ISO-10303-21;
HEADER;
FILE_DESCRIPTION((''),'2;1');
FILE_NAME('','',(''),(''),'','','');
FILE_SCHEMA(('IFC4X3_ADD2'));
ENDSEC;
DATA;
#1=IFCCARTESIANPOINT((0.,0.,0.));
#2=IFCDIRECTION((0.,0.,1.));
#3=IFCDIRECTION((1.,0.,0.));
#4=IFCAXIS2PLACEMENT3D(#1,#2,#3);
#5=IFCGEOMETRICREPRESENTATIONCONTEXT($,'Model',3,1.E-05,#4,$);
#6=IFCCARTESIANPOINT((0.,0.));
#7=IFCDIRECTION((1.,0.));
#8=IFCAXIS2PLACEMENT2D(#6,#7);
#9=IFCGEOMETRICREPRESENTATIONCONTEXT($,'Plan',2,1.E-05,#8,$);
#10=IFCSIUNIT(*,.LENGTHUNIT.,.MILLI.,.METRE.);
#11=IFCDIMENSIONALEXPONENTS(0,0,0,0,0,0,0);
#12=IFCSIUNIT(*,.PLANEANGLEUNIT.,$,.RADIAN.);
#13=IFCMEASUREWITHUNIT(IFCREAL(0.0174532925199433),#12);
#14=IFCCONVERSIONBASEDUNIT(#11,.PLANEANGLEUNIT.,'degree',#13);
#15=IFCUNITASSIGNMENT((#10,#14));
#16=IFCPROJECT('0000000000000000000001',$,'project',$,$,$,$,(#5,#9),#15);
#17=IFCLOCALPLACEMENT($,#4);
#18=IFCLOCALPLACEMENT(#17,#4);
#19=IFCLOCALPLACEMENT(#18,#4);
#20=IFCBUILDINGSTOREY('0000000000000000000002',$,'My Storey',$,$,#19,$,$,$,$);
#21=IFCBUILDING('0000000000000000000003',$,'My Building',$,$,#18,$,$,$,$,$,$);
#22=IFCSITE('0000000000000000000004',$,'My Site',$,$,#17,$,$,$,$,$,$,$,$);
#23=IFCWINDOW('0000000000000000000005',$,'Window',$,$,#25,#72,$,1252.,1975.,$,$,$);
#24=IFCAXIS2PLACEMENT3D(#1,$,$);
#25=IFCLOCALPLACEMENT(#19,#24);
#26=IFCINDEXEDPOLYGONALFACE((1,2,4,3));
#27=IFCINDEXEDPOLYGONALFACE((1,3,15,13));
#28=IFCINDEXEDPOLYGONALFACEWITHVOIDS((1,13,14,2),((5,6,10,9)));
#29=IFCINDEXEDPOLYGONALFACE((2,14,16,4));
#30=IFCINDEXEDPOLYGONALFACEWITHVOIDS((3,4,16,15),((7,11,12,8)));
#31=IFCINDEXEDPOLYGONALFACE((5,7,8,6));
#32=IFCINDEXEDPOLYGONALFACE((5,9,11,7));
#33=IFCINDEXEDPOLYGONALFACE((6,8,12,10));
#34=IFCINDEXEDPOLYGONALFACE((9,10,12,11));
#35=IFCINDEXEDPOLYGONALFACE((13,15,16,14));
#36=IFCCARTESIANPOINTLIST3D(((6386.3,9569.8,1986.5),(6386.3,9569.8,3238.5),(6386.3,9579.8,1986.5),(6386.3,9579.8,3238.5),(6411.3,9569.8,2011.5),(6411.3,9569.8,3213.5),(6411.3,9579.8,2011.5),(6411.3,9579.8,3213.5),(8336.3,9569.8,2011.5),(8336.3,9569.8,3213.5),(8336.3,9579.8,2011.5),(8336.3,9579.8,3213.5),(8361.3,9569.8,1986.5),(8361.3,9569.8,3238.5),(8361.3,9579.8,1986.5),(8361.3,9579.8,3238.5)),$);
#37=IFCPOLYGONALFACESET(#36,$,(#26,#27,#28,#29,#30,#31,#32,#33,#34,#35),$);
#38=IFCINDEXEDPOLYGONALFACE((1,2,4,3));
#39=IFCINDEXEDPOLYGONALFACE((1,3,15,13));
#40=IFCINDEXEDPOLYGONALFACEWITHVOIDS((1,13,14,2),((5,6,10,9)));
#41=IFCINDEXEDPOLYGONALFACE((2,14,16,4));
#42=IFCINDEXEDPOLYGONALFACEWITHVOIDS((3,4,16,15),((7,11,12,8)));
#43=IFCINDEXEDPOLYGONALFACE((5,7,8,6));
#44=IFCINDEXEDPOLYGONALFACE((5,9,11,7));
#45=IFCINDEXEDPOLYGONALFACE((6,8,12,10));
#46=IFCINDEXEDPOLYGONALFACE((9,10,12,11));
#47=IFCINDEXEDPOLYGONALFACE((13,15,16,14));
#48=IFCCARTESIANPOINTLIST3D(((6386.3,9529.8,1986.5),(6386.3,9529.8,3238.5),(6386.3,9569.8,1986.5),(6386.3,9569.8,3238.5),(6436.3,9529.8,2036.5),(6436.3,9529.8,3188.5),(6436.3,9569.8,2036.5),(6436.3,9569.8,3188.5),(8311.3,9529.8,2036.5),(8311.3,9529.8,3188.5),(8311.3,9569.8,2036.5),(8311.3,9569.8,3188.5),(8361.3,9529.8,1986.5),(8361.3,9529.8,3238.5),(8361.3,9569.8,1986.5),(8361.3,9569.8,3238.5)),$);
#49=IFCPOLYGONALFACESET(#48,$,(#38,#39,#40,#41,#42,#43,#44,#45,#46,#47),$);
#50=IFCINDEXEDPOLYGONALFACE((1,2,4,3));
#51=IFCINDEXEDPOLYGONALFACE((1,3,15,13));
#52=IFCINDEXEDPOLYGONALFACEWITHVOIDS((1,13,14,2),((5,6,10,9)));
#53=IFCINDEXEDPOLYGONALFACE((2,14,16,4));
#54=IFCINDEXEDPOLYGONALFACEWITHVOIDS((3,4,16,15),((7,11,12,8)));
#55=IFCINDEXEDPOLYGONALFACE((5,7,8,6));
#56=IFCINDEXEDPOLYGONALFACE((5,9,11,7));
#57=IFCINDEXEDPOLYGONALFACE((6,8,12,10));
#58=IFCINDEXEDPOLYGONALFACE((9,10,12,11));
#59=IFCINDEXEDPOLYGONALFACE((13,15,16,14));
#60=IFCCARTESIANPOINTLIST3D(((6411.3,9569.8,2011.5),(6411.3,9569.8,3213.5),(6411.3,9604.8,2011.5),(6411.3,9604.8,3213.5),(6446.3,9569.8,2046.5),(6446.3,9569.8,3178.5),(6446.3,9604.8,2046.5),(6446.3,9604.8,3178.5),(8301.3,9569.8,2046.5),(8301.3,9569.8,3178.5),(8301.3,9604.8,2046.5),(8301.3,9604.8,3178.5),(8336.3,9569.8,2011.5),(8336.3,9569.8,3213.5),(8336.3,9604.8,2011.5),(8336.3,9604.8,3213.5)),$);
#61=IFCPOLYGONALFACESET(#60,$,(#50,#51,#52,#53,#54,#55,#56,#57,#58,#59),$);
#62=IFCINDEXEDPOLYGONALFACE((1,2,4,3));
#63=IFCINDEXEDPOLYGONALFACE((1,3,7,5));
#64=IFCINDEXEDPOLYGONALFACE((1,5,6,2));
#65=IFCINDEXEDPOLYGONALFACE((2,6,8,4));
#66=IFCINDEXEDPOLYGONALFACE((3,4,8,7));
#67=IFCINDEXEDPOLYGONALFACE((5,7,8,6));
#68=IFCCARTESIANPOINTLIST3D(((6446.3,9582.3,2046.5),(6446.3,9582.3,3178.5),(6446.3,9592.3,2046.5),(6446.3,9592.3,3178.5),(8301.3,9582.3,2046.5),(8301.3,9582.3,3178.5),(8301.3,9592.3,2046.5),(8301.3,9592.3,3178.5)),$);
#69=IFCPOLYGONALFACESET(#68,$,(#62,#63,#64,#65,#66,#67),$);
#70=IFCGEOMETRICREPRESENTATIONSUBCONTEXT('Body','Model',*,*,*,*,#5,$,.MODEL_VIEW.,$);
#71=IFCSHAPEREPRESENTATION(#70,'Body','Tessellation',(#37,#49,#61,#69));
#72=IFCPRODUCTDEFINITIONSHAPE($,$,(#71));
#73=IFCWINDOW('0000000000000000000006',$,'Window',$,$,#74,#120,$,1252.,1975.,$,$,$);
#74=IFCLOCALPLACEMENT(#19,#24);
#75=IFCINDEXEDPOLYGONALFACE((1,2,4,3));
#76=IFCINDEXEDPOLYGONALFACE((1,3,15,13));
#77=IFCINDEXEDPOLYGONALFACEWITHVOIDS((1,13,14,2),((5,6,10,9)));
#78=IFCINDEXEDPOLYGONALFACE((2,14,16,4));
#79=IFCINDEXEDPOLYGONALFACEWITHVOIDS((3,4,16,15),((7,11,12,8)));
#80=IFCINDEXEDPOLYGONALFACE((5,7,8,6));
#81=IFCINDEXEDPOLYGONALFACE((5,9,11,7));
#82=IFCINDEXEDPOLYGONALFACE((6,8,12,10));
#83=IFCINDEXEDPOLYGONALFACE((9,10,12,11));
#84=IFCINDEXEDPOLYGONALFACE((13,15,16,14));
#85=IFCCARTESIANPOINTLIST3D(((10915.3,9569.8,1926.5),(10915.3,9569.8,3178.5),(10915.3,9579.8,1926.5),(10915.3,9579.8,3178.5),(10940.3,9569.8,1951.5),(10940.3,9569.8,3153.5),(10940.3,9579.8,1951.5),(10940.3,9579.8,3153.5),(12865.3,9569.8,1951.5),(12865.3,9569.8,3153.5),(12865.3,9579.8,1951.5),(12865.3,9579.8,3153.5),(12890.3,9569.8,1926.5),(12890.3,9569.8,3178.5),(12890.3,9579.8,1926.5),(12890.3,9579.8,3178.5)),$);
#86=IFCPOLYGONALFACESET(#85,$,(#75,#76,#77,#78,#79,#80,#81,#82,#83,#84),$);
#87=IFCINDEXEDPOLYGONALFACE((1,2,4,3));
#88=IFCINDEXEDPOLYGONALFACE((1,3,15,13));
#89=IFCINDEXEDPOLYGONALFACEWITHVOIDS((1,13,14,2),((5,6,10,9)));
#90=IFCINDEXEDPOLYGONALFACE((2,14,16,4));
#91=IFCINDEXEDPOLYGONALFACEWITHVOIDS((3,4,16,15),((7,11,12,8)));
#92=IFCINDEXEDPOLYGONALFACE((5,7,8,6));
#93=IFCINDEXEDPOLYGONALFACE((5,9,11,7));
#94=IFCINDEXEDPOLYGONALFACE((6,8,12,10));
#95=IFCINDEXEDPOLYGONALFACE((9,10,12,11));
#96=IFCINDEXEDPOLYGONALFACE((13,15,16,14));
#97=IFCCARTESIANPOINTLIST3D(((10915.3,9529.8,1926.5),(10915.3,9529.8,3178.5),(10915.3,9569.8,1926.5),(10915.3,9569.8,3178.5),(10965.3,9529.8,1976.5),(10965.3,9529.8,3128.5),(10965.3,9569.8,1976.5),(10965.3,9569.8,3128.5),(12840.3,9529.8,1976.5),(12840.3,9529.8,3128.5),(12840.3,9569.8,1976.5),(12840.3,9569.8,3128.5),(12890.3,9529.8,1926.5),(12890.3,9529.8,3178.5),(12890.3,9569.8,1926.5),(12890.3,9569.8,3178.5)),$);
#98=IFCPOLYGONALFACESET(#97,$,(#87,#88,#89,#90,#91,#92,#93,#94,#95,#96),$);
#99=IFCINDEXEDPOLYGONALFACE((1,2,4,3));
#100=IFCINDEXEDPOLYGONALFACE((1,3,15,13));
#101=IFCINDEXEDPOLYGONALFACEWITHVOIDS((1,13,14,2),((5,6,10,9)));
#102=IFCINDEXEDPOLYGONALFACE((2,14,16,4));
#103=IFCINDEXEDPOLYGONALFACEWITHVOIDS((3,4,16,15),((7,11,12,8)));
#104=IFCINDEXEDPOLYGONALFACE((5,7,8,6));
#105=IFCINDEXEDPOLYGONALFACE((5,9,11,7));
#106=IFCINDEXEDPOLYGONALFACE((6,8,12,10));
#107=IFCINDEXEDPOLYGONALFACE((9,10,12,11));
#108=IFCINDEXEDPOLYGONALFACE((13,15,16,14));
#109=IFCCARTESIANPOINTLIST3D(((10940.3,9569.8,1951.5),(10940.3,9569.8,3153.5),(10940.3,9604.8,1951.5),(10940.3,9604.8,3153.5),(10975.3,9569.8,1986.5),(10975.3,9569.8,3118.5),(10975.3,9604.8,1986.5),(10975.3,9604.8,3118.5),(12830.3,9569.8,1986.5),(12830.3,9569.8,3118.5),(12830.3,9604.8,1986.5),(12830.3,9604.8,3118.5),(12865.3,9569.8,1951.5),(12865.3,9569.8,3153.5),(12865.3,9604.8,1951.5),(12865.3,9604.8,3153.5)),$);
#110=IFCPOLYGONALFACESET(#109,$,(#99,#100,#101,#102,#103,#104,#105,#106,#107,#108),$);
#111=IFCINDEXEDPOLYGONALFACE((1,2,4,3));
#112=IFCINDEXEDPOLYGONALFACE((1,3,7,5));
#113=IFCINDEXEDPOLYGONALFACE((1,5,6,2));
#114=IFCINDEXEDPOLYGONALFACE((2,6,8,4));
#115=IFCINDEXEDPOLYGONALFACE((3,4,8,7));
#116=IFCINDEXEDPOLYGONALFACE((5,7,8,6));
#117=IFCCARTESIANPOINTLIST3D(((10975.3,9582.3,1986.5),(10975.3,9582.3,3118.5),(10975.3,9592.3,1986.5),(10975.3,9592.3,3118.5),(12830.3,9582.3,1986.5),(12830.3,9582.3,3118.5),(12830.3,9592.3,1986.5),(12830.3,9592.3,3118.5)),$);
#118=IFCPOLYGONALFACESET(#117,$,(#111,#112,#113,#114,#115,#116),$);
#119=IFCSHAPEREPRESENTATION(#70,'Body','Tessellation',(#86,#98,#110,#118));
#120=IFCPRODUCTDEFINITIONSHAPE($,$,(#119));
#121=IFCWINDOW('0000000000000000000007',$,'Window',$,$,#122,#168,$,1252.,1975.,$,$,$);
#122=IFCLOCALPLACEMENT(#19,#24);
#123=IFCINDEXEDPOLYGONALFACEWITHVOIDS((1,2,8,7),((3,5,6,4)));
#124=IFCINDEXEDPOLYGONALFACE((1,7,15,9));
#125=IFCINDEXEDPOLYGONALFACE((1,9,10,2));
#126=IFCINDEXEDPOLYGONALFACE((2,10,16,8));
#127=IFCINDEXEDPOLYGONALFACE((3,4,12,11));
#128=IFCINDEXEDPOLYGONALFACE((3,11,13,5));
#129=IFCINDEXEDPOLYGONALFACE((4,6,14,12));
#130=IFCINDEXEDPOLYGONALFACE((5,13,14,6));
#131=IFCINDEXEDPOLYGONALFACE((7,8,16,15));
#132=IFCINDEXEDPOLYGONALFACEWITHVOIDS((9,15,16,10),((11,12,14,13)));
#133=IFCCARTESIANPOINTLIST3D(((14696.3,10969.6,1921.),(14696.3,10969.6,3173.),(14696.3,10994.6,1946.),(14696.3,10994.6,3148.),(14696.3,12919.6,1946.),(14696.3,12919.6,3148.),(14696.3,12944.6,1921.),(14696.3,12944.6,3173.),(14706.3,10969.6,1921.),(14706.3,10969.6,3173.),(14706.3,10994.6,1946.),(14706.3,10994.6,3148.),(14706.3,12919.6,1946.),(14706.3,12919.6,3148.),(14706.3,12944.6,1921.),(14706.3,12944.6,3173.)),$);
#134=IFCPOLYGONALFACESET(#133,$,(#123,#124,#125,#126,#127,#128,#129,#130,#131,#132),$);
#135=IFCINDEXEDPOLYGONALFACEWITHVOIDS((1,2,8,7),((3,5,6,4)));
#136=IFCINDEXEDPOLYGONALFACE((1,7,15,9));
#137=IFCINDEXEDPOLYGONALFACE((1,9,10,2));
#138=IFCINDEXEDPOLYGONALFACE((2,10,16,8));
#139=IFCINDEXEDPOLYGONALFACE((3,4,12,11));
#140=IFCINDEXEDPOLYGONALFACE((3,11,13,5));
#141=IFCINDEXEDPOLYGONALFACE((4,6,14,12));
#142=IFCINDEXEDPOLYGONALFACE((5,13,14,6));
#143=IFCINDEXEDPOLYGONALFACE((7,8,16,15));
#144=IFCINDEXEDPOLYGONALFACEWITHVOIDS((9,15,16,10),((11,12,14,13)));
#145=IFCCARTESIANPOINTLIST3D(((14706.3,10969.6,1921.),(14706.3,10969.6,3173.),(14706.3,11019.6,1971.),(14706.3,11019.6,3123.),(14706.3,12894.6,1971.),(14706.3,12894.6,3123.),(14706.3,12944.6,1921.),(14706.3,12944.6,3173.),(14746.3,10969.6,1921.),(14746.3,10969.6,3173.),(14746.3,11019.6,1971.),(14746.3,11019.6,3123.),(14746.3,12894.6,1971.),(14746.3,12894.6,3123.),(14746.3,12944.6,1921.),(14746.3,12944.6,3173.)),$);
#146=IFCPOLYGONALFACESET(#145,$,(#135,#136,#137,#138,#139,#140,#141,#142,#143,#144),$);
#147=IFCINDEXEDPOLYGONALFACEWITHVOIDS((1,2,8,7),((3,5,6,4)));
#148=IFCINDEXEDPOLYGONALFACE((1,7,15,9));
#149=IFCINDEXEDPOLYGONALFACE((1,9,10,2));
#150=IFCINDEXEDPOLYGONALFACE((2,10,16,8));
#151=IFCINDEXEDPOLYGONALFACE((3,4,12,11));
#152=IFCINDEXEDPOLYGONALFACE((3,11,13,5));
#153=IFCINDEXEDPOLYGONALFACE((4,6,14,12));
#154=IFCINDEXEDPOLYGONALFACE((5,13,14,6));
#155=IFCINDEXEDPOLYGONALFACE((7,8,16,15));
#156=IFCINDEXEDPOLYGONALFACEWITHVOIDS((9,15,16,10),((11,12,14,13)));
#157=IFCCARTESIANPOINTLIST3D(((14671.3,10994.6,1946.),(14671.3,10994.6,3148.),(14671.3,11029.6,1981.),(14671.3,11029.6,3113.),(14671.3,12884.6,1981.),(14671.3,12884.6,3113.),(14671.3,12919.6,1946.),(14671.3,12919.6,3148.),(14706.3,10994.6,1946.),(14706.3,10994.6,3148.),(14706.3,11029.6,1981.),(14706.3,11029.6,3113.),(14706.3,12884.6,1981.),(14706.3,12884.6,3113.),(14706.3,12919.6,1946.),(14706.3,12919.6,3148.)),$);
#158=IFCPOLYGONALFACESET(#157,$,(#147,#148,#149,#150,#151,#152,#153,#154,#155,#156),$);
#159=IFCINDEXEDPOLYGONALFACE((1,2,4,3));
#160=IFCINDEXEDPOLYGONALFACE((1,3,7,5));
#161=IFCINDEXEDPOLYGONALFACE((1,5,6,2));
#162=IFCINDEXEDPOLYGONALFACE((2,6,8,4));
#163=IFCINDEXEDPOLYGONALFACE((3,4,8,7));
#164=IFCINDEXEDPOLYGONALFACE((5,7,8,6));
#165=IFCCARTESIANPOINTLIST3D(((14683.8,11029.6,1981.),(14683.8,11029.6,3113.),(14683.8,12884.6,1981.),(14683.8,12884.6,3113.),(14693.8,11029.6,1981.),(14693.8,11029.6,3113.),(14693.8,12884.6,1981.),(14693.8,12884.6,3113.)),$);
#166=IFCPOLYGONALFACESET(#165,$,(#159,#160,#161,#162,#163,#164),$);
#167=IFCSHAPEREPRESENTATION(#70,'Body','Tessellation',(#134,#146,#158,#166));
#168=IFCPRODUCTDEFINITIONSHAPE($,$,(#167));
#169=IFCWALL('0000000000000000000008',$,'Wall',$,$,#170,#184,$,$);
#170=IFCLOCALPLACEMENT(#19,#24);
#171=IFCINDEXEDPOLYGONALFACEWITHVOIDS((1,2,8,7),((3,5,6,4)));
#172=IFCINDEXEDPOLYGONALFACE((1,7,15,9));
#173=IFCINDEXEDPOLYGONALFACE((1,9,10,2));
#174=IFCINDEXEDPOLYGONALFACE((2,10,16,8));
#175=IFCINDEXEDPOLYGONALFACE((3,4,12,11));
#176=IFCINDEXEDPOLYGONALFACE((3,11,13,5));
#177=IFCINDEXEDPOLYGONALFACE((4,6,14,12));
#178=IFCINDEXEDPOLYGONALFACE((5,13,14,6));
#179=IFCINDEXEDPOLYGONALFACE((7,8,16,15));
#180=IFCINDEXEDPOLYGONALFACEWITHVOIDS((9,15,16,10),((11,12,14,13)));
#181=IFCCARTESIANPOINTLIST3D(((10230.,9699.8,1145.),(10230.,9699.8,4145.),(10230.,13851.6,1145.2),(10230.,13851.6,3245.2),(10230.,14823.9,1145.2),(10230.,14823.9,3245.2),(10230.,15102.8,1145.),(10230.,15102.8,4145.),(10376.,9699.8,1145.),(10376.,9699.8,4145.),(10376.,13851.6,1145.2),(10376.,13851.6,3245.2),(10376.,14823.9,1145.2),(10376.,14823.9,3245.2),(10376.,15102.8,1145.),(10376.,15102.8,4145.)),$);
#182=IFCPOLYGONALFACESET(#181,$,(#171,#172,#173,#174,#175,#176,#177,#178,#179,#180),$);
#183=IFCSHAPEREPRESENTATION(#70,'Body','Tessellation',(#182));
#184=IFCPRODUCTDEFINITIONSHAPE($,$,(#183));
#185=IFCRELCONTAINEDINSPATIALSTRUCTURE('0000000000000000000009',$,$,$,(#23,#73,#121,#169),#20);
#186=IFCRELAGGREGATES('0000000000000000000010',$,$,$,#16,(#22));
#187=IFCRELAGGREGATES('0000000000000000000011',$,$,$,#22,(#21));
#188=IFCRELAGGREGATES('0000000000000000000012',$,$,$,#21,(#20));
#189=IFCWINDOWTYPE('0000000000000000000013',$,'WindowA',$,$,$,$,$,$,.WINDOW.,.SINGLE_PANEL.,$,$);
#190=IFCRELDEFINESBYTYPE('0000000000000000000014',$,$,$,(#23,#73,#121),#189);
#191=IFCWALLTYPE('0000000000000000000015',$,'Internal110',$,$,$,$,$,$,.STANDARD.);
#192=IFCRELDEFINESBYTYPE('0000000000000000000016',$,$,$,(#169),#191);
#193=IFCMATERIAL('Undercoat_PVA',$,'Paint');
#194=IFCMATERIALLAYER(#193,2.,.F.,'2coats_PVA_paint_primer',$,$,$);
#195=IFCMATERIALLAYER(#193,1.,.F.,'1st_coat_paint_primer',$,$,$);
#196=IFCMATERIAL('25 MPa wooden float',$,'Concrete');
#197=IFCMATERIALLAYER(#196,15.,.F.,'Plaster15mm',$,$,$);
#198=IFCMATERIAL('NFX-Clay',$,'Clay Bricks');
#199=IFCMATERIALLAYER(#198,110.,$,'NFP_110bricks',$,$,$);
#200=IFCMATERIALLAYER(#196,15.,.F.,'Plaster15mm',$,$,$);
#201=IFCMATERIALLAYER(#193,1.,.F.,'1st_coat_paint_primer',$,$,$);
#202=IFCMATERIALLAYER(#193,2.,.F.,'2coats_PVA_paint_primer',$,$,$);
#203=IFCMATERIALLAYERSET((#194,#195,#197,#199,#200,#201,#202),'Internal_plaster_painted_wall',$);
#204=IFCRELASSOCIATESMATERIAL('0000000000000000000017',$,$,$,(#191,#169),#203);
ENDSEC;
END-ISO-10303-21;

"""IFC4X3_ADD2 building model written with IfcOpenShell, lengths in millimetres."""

from ifc_helpers import new_model, entity, si_unit, converted_unit, frame, origin_with_axes, origin_2d_with_axis, place, context, subcontext, project, spatial, line, indexed_curve, outline, extrude, shape, source, transform, mapped, material, layer, layer_set, layer_usage, type_object, type_shapes, element, save


model = new_model("IFC4X3_ADD2")

# Units and contexts
model_context = context("Model", 3, precision=1e-05, world=origin_with_axes())
plan_context = context("Plan", 2, precision=1e-05, world=origin_2d_with_axis())
body_context_1 = subcontext(model_context, "Body", "Model", "MODEL_VIEW")
body_context_2 = subcontext(plan_context, "Body", "Plan", "PLAN_VIEW")
ifc_project = project(units=[si_unit("LENGTHUNIT", "METRE", prefix="MILLI"), converted_unit("PLANEANGLEUNIT", "degree", entity("IfcReal", 0.0174532925199433), si_unit("PLANEANGLEUNIT", "RADIAN"), dimensions=[0, 0, 0, 0, 0, 0, 0])], contexts=[model_context, plan_context])

# Site, building, storey
site_placement = place(None, origin_with_axes())
site = spatial("IfcSite", under=ifc_project, at=site_placement, Name="My Site")
building_placement = place(site_placement, origin_with_axes())
building = spatial("IfcBuilding", under=site, at=building_placement, Name="My Building")
storey_placement = place(building_placement, origin_with_axes())
storey = spatial("IfcBuildingStorey", under=building, at=storey_placement, Name="My Storey")

# Windows
window_type = type_object("IfcWindowType", Name="WindowA", PartitioningType="SINGLE_PANEL", PredefinedType="WINDOW")
shared_shape_1 = source(origin_with_axes(), body_context_1, "Body", "SweptSolid", [
    extrude(outline(indexed_curve([(0.0, 0.0), (1975.0, 0.0), (1975.0, 1252.0), (0.0, 1252.0)], segments=[line(1, 2, 3, 4, 1)]), holes=[indexed_curve([(25.0, 25.0), (1950.0, 25.0), (1950.0, 1227.0), (25.0, 1227.0)], segments=[line(1, 2, 3, 4, 1)])]), frame((0.0, 90.0, 0.0), z_axis=(0.0, -1.0, 0.0), x_axis=(1.0, 0.0, 0.0)), (0.0, 0.0, -1.0), 10.0),
    extrude(outline(indexed_curve([(0.0, 0.0), (1975.0, 0.0), (1975.0, 1252.0), (0.0, 1252.0)], segments=[line(1, 2, 3, 4, 1)]), holes=[indexed_curve([(50.0, 50.0), (1925.0, 50.0), (1925.0, 1202.0), (50.0, 1202.0)], segments=[line(1, 2, 3, 4, 1)])]), frame((0.0, 50.0, 0.0), z_axis=(0.0, -1.0, 0.0), x_axis=(1.0, 0.0, 0.0)), (0.0, 0.0, -1.0), 40.0),
    extrude(outline(indexed_curve([(0.0, 0.0), (1925.0, 0.0), (1925.0, 1202.0), (0.0, 1202.0)], segments=[line(1, 2, 3, 4, 1)]), holes=[indexed_curve([(35.0, 35.0), (1890.0, 35.0), (1890.0, 1167.0), (35.0, 1167.0)], segments=[line(1, 2, 3, 4, 1)])]), frame((25.0, 90.0, 25.0), z_axis=(0.0, -1.0, 0.0), x_axis=(1.0, 0.0, 0.0)), (0.0, 0.0, -1.0), 35.0),
    extrude(outline(indexed_curve([(35.0, 35.0), (1890.0, 35.0), (1890.0, 1167.0), (35.0, 1167.0)], segments=[line(1, 2, 3, 4, 1)])), frame((25.0, 102.5, 25.0), z_axis=(0.0, -1.0, 0.0), x_axis=(1.0, 0.0, 0.0)), (0.0, 0.0, -1.0), 10.0),
])
shared_shape_2 = source(origin_with_axes(), body_context_2, "Body", "Curve2D", [
    entity("IfcIndexedPolyCurve", entity("IfcCartesianPointList2D", [[50.0, 50.0], [1925.0, 50.0]])),
    entity("IfcIndexedPolyCurve", entity("IfcCartesianPointList2D", [[0.0, 100.0], [25.0, 100.0], [25.0, 90.0], [50.0, 90.0], [50.0, 50.0], [0.0, 50.0]]), [entity("IfcLineIndex", [1, 2, 3, 4, 5, 6, 1])]),
    entity("IfcIndexedPolyCurve", entity("IfcCartesianPointList2D", [[1975.0, 100.0], [1950.0, 100.0], [1950.0, 90.0], [1925.0, 90.0], [1925.0, 50.0], [1975.0, 50.0]]), [entity("IfcLineIndex", [1, 2, 3, 4, 5, 6, 1])]),
    entity("IfcIndexedPolyCurve", entity("IfcCartesianPointList2D", [[25.0, 90.0], [60.0, 90.0], [60.0, 125.0], [25.0, 125.0]]), [entity("IfcLineIndex", [1, 2, 3, 4, 1])]),
    entity("IfcIndexedPolyCurve", entity("IfcCartesianPointList2D", [[1950.0, 90.0], [1915.0, 90.0], [1915.0, 125.0], [1950.0, 125.0]]), [entity("IfcLineIndex", [1, 2, 3, 4, 1])]),
    entity("IfcIndexedPolyCurve", entity("IfcCartesianPointList2D", [[60.0, 90.0], [1915.0, 90.0]])),
    entity("IfcIndexedPolyCurve", entity("IfcCartesianPointList2D", [[60.0, 125.0], [1915.0, 125.0]])),
    entity("IfcIndexedPolyCurve", entity("IfcCartesianPointList2D", [[60.0, 107.5], [1915.0, 107.5]])),
])
type_shapes(window_type, [shared_shape_1, shared_shape_2])
for number, where, z_axis, x_axis, name in (
    (1, (6386.3, 9479.8, 1986.5), (0.0, 0.0, 1.0), (1.0, 0.0, 0.0), "Window"),
    (2, (10915.3, 9479.8, 1926.5), (0.0, 0.0, 1.0), (1.0, 0.0, 0.0), "Window"),
    (3, (14796.3, 10969.6, 1921.0), (0.0, 0.0, 1.0), (0.0, 1.0, 0.0), "Window"),
):
    element("IfcWindow", number, at=place(storey_placement, frame(where, z_axis=z_axis, x_axis=x_axis)), inside=storey, type_object=window_type, Name=name, OverallHeight=1252.0, OverallWidth=1975.0, shapes=[
        shape(body_context_1, "Body", "MappedRepresentation", [mapped(shared_shape_1, transform((0.0, 0.0, 0.0), x_axis=(1.0, 0.0, 0.0), y_axis=(0.0, 1.0, 0.0), z_axis=(0.0, 0.0, 1.0), scale=1.0))]),
        shape(body_context_2, "Body", "MappedRepresentation", [mapped(shared_shape_2, transform((0.0, 0.0, 0.0), x_axis=(1.0, 0.0, 0.0), y_axis=(0.0, 1.0, 0.0), z_axis=(0.0, 0.0, 1.0), scale=1.0))]),
    ])

# Wall, opening
ifc_material_1 = material(Name="Undercoat_PVA", Category="Paint")
ifc_layer_1 = layer(ifc_material_1, 2.0, ventilated=False, Name="2coats_PVA_paint_primer")
ifc_layer_2 = layer(ifc_material_1, 1.0, ventilated=False, Name="1st_coat_paint_primer")
ifc_material_2 = material(Name="25 MPa wooden float", Category="Concrete")
ifc_layer_3 = layer(ifc_material_2, 15.0, ventilated=False, Name="Plaster15mm")
ifc_material_3 = material(Name="NFX-Clay", Category="Clay Bricks")
ifc_layer_4 = layer(ifc_material_3, 110.0, Name="NFP_110bricks")
ifc_layer_5 = layer(ifc_material_2, 15.0, ventilated=False, Name="Plaster15mm")
ifc_layer_6 = layer(ifc_material_1, 1.0, ventilated=False, Name="1st_coat_paint_primer")
ifc_layer_7 = layer(ifc_material_1, 2.0, ventilated=False, Name="2coats_PVA_paint_primer")
ifc_layer_set_1 = layer_set([ifc_layer_1, ifc_layer_2, ifc_layer_3, ifc_layer_4, ifc_layer_5, ifc_layer_6, ifc_layer_7], Name="Internal_plaster_painted_wall")
ifc_layer_usage_1 = layer_usage(ifc_layer_set_1, "AXIS2", "POSITIVE", 0.0)
wall_type_1 = type_object("IfcWallType", Name="Internal110", PredefinedType="STANDARD", material=ifc_layer_set_1)
wall_1_placement = place(storey_placement, frame((10230.0, 15102.8, 1145.0), z_axis=(0.0, 0.0, 1.0), x_axis=(0.000001, -1.0, 0.0)))
wall_1 = element("IfcWall", 4, at=wall_1_placement, inside=storey, type_object=wall_type_1, material=ifc_layer_usage_1, Name="Wall", context=body_context_1, shape_type="SweptSolid", body=[
    extrude(outline(indexed_curve([(0.0, 0.0), (0.0, 146.0), (5403.0, 146.0), (5403.0, 0.0)], segments=[line(1, 2, 3, 4, 1)])), origin_with_axes(), (0.0, 0.0, 1.0), 3000.0),
])
opening_1_placement = place(wall_1_placement, frame((1251.1, -189.0, 0.2), z_axis=(0.0, 0.0, 1.0), x_axis=(0.000001, 1.0, 0.0)))
element("IfcOpeningElement", 5, at=opening_1_placement, cuts=wall_1, PredefinedType="OPENING", context=body_context_1, shape_type="SweptSolid", body=[
    extrude(outline(indexed_curve([(0.0, 972.3), (500.0, 972.3), (500.0, 0.0), (0.0, 0.0), (0.0, 972.3)])), origin_with_axes(), (0.0, 0.0, 1.0), 2100.0),
])

save(model, "model.ifc")
